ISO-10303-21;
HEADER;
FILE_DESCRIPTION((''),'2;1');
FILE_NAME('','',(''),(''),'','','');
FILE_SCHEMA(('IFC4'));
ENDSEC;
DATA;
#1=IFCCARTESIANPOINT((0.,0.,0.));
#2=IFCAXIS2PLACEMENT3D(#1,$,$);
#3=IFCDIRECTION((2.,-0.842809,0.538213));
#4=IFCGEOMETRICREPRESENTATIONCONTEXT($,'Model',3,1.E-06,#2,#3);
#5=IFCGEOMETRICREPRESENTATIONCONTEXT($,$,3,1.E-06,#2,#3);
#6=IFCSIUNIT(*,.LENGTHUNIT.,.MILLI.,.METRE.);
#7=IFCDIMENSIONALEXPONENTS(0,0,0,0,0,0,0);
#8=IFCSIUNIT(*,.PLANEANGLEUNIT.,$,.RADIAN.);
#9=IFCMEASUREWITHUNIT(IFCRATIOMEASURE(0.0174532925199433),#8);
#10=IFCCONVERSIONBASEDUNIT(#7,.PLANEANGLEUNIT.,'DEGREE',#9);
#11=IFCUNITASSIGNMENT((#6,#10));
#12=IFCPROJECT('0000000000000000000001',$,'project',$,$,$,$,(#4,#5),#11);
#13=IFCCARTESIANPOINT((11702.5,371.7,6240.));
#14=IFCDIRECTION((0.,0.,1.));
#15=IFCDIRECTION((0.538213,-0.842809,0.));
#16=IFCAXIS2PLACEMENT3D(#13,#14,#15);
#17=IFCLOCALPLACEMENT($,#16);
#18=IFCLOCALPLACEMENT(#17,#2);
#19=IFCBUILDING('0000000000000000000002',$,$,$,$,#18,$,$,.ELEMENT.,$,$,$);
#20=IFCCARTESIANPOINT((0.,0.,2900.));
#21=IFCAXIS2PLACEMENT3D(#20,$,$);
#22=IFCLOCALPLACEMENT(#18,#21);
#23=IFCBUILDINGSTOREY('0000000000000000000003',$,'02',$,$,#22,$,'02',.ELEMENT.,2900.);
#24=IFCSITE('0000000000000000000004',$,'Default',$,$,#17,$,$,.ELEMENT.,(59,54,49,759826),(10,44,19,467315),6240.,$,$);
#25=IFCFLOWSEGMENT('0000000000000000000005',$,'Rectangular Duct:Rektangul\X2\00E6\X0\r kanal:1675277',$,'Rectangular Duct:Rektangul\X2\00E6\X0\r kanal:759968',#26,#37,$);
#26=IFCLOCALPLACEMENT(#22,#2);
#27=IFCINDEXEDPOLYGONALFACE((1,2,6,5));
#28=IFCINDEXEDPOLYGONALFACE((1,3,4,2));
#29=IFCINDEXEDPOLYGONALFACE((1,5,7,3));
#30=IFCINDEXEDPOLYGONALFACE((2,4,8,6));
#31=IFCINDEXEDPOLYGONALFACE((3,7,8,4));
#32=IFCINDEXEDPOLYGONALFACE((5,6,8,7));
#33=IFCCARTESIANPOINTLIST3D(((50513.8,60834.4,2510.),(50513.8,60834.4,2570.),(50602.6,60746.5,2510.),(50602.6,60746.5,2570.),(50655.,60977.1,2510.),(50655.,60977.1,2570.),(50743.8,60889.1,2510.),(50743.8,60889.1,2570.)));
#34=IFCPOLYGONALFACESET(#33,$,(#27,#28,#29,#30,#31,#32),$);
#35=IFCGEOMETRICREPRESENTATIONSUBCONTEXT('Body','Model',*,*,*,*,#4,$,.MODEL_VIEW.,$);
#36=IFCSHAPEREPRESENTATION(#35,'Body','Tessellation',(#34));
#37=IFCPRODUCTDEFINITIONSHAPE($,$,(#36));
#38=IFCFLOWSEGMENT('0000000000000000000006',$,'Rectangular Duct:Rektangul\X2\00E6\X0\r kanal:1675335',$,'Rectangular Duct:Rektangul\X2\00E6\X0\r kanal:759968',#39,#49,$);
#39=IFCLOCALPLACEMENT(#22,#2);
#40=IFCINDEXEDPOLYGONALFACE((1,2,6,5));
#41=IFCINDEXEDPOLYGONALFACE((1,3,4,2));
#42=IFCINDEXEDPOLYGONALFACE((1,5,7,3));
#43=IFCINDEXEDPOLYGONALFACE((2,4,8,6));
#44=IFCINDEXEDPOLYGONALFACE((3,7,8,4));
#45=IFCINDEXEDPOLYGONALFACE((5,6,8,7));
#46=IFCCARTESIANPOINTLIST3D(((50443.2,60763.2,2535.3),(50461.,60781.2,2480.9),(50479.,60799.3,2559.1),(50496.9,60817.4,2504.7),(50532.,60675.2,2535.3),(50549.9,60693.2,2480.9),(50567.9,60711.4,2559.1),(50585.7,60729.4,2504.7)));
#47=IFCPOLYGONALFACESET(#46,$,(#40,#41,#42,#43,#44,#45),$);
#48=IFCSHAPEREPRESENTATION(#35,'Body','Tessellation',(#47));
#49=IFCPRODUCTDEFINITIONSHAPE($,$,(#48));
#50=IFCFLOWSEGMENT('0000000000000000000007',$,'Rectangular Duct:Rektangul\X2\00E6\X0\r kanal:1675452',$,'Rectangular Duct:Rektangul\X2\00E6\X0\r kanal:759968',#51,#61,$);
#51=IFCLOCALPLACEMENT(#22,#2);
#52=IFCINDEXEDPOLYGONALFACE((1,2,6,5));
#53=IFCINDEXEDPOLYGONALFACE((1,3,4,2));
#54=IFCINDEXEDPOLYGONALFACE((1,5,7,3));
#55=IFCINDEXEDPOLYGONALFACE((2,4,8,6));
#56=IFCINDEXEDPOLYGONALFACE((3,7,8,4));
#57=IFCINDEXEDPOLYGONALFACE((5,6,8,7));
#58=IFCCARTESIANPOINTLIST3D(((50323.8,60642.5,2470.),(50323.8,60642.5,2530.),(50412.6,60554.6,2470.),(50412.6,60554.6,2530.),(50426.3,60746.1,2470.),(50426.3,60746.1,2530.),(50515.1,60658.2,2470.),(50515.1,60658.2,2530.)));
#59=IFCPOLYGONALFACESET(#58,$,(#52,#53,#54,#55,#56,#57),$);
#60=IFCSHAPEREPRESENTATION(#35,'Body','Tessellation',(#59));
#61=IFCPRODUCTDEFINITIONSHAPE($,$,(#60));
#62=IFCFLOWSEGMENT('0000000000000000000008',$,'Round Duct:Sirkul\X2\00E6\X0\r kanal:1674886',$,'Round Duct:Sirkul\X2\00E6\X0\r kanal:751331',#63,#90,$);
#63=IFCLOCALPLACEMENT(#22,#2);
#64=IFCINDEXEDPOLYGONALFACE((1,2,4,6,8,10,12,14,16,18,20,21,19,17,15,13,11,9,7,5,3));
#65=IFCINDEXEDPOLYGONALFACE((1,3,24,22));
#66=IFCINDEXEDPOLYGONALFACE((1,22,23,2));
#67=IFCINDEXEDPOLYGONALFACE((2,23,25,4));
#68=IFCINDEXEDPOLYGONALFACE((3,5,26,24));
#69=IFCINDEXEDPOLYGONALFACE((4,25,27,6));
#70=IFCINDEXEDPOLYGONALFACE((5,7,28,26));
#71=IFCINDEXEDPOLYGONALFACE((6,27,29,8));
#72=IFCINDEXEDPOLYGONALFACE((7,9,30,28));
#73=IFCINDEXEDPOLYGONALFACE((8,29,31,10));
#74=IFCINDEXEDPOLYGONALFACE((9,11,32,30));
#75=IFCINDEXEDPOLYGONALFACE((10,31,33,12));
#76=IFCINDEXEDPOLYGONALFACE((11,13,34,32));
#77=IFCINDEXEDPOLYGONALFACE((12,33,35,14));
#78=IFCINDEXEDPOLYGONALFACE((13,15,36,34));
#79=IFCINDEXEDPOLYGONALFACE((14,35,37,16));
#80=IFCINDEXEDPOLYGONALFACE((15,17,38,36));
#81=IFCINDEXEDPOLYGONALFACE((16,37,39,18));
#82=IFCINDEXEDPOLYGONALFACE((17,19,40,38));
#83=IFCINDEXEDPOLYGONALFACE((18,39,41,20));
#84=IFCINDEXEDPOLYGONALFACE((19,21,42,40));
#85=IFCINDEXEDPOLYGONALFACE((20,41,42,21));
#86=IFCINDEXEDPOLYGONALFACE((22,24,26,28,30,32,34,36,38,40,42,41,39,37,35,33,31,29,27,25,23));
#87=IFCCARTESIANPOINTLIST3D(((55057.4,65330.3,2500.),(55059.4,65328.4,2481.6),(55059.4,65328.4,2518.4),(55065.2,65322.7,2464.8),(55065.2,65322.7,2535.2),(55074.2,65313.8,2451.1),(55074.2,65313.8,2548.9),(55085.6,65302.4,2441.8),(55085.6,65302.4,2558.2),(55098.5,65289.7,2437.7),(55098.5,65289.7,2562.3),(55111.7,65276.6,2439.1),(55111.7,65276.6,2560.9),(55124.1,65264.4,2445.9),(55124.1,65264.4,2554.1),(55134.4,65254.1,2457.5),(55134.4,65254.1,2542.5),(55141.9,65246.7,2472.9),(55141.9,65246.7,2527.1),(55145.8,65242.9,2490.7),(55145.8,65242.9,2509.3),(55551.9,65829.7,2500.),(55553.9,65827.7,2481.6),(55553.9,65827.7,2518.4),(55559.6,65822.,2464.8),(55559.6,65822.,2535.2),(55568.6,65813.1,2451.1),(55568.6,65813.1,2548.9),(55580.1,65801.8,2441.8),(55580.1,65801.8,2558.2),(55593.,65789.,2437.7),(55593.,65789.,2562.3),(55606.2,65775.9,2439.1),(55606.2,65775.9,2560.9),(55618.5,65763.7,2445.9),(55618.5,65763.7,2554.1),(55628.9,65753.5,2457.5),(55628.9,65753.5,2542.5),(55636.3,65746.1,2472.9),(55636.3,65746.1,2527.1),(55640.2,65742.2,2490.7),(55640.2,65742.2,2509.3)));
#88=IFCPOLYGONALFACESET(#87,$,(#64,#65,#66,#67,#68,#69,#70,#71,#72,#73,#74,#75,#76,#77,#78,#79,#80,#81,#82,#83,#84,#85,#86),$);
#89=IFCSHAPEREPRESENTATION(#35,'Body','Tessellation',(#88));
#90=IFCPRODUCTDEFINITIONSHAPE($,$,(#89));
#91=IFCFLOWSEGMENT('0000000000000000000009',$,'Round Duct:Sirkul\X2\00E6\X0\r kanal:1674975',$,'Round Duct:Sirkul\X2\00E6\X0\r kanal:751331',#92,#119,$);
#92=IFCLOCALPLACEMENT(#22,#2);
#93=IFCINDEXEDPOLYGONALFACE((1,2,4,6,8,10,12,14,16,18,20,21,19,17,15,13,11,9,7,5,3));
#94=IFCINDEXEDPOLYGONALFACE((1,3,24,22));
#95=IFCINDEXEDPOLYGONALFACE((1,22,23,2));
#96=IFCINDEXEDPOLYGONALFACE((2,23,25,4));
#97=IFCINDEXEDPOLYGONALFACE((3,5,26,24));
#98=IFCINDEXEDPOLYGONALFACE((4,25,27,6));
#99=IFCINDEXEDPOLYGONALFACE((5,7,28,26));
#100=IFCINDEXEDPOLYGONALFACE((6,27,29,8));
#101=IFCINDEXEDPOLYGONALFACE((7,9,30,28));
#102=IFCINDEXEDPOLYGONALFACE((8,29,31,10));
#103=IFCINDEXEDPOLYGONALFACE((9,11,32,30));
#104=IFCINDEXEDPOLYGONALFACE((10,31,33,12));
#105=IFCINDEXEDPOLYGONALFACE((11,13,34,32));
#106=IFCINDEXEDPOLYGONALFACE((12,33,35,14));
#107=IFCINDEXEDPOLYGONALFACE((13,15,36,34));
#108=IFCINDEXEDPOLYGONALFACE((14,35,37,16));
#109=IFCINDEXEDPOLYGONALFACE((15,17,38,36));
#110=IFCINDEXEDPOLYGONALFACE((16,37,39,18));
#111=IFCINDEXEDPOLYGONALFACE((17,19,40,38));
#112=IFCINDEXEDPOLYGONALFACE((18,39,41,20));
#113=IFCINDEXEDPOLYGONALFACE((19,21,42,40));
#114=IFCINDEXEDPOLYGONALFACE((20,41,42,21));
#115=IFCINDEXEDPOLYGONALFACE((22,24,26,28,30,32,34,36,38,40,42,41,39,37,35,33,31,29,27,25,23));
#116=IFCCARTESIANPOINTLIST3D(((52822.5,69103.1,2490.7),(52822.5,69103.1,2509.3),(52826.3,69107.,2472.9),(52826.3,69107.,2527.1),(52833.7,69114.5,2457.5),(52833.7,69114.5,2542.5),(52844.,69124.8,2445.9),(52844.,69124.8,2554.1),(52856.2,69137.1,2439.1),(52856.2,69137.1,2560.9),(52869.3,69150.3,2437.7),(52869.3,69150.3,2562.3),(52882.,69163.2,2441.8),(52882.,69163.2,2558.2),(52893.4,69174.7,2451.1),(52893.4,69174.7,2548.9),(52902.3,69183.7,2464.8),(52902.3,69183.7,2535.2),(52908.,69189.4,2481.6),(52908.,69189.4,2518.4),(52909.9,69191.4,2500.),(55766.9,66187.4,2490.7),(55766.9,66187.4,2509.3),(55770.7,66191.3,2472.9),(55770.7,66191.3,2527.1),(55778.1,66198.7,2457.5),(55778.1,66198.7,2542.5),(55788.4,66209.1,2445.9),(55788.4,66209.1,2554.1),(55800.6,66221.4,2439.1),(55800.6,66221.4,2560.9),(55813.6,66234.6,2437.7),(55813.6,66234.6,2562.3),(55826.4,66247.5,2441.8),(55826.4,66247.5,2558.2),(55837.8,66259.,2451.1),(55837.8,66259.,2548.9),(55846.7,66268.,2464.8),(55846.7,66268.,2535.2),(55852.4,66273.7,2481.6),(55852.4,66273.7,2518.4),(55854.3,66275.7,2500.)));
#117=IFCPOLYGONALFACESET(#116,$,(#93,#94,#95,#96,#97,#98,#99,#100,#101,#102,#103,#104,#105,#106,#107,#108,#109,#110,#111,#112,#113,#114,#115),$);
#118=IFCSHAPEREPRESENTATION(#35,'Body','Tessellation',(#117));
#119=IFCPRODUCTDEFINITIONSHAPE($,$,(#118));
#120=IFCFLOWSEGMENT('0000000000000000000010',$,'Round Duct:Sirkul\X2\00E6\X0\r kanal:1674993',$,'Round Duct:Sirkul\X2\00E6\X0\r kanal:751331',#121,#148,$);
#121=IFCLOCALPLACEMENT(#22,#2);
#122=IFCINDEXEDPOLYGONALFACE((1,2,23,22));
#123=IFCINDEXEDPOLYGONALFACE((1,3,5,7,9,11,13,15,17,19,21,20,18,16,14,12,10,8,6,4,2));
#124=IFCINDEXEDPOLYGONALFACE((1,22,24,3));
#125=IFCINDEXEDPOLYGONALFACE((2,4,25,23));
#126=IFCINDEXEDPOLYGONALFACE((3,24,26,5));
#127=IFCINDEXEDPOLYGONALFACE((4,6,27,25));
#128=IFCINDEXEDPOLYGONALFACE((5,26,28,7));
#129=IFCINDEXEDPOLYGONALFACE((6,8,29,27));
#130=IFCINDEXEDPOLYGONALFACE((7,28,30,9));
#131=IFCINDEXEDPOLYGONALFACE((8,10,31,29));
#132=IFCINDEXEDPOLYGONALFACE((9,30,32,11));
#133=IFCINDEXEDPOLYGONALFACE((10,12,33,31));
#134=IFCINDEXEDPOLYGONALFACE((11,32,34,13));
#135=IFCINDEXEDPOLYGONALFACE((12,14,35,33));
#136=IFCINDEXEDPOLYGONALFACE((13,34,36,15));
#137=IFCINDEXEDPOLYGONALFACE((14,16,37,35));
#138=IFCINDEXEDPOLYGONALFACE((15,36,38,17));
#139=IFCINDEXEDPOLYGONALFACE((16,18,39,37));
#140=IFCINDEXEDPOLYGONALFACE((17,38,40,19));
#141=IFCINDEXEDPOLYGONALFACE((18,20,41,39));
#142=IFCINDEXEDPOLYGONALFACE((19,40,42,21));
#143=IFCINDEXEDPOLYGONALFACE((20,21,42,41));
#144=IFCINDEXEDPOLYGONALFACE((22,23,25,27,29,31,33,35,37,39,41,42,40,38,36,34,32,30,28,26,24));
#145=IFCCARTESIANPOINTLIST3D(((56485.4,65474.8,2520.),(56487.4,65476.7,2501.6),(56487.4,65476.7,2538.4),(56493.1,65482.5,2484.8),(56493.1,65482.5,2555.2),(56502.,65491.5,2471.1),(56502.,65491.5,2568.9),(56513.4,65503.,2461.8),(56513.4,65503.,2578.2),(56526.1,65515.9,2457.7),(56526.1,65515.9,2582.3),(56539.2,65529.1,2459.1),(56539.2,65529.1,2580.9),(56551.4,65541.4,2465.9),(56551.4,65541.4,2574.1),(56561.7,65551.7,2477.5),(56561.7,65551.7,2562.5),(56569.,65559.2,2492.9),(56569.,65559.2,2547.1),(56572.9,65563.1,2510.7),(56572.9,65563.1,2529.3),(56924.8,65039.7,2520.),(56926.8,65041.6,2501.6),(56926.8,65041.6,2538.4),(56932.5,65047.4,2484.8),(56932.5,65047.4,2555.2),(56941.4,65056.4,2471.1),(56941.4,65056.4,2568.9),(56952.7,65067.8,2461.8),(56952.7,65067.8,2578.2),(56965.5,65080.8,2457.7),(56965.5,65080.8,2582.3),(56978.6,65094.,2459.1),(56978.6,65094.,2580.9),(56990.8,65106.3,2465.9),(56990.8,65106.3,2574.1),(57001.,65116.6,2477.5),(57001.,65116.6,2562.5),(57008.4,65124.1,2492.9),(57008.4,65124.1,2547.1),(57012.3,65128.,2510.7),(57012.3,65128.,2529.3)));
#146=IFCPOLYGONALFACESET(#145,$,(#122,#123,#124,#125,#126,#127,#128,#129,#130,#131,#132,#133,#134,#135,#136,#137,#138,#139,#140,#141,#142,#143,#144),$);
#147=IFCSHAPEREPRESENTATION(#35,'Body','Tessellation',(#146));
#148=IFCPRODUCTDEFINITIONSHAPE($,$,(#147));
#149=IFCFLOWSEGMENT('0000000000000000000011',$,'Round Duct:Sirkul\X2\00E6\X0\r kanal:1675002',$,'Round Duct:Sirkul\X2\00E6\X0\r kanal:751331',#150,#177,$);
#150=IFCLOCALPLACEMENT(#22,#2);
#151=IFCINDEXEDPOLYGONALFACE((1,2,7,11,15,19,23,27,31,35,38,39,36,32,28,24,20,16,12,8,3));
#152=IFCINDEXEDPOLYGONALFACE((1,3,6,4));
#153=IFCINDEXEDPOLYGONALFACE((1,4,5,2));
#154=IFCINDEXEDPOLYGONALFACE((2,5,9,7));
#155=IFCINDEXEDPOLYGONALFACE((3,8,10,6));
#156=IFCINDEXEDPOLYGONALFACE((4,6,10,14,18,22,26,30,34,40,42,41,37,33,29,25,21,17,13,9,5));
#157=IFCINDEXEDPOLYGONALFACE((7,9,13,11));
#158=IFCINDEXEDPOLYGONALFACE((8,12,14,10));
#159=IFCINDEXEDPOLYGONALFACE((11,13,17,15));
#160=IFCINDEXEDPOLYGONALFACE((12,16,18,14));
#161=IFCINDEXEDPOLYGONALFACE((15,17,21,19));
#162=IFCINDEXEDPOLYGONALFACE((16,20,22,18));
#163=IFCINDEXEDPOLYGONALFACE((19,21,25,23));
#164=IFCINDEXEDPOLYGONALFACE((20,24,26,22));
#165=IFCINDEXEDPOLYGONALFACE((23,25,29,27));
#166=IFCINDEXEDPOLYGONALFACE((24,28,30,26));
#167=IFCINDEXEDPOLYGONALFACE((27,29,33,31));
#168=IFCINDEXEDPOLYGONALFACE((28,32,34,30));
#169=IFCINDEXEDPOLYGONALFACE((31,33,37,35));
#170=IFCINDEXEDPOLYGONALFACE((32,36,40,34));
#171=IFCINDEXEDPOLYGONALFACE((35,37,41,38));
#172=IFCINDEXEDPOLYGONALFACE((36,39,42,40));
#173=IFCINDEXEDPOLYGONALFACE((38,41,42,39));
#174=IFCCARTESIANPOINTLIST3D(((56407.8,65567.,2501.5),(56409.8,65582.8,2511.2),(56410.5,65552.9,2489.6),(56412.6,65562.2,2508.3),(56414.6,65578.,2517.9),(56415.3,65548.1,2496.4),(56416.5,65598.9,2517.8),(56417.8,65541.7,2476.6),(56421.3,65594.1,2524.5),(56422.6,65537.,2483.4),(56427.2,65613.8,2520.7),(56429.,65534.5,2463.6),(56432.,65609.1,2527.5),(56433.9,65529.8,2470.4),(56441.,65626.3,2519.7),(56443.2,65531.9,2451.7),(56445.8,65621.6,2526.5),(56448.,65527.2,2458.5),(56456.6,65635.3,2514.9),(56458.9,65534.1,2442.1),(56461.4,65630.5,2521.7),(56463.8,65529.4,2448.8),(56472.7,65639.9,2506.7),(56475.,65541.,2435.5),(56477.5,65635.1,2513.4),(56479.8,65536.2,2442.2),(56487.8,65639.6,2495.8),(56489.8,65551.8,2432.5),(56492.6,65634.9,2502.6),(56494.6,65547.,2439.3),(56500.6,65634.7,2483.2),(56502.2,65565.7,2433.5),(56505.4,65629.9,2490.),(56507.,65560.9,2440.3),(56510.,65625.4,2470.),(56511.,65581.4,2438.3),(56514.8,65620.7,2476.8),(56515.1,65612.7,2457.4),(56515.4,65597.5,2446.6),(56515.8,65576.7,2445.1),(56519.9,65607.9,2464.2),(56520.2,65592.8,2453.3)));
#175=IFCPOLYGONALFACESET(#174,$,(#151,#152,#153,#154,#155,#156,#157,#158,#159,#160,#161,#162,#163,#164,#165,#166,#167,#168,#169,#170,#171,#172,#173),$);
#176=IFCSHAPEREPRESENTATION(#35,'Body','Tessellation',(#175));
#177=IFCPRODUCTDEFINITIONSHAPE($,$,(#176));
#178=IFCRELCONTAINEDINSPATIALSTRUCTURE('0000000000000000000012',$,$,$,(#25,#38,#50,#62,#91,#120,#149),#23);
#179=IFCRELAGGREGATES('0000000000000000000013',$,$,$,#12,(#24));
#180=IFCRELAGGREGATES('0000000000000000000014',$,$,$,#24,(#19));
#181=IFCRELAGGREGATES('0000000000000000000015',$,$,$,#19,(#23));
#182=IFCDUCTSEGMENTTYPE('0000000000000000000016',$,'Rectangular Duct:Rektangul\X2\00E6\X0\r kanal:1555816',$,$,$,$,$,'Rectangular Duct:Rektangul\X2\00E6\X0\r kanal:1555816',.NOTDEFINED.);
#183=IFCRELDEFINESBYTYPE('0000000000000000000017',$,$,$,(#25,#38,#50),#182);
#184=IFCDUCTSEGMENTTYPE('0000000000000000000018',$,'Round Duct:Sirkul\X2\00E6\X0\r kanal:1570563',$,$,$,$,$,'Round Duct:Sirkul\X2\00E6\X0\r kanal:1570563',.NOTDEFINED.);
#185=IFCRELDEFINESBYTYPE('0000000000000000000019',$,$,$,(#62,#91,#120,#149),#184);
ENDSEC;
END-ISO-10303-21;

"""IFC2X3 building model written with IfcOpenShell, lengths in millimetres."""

from ifc_helpers import new_model, entity, si_unit, converted_unit, direction, frame, frame_2d, origin, origin_2d_with_axis, place, context, subcontext, project, spatial, rectangle, circle, extrude, type_object, element, save


model = new_model("IFC2X3")

# Units and contexts
model_context = context("Model", 3, precision=1e-06, world=origin(), true_north=direction((2.0, -0.842809, 0.538213)))
context_of_model = context(None, 3, precision=1e-06, world=origin(), true_north=direction((2.0, -0.842809, 0.538213)))
body_context = subcontext(model_context, "Body", "Model", "MODEL_VIEW")
ifc_project = project(units=[si_unit("LENGTHUNIT", "METRE", prefix="MILLI"), converted_unit("PLANEANGLEUNIT", "DEGREE", entity("IfcRatioMeasure", 0.0174532925199433), si_unit("PLANEANGLEUNIT", "RADIAN"), dimensions=[0, 0, 0, 0, 0, 0, 0])], contexts=[model_context, context_of_model])

# Site, building, storey
site_placement = place(None, frame((11702.5, 371.7, 6240.0), z_axis=(0.0, 0.0, 1.0), x_axis=(0.538213, -0.842809, 0.0)))
site = spatial("IfcSite", under=ifc_project, at=site_placement, Name="Default", CompositionType="ELEMENT", RefLatitude=(59, 54, 49, 759826), RefLongitude=(10, 44, 19, 467315), RefElevation=6240.0)
building_placement = place(site_placement, origin())
building = spatial("IfcBuilding", under=site, at=building_placement, CompositionType="ELEMENT")
storey_placement = place(building_placement, frame((0.0, 0.0, 2900.0)))
storey = spatial("IfcBuildingStorey", under=building, at=storey_placement, Name="02", LongName="02", CompositionType="ELEMENT", Elevation=2900.0)

# Flow segments
duct_segment_type_1 = type_object("IfcDuctSegmentType", Name="Rectangular Duct:Rektangulær kanal:1555816", ElementType="Rectangular Duct:Rektangulær kanal:1555816", PredefinedType="NOTDEFINED")
flow_segment_1_placement = place(storey_placement, origin())
element("IfcFlowSegment", 1, at=flow_segment_1_placement, inside=storey, type_object=duct_segment_type_1, Name="Rectangular Duct:Rektangulær kanal:1675277", ObjectType="Rectangular Duct:Rektangulær kanal:759968", context=body_context, shape_type="SweptSolid", body=[
    extrude(rectangle(XDim=200.8, YDim=125.0, at=frame_2d((0.0, 0.0), x_axis=(1.0, 0.0))), frame((50628.8, 60861.8, 2510.0), z_axis=(0.0, 0.0, 1.0), x_axis=(-0.703643, -0.710554, 0.0)), (0.0, 0.0, 1.0), 60.0),
])
flow_segment_2_placement = place(storey_placement, origin())
element("IfcFlowSegment", 2, at=flow_segment_2_placement, inside=storey, type_object=duct_segment_type_1, Name="Rectangular Duct:Rektangulær kanal:1675335", ObjectType="Rectangular Duct:Rektangulær kanal:759968", context=body_context, shape_type="SweptSolid", body=[
    extrude(rectangle(XDim=60.0, YDim=56.2, at=frame_2d((0.0, 0.0), x_axis=(0.0, 1.0))), frame((50470.0, 60790.3, 2520.0), z_axis=(0.710554, -0.703643, 0.0), x_axis=(-0.637717, -0.643981, -0.422618)), (0.0, 0.0, 1.0), 125.0),
])
flow_segment_3_placement = place(storey_placement, origin())
element("IfcFlowSegment", 3, at=flow_segment_3_placement, inside=storey, type_object=duct_segment_type_1, Name="Rectangular Duct:Rektangulær kanal:1675452", ObjectType="Rectangular Duct:Rektangulær kanal:759968", context=body_context, shape_type="SweptSolid", body=[
    extrude(rectangle(XDim=145.8, YDim=125.0, at=origin_2d_with_axis()), frame((50419.5, 60650.4, 2470.0), z_axis=(0.0, 0.0, 1.0), x_axis=(-0.703643, -0.710554, 0.0)), (0.0, 0.0, 1.0), 60.0),
])
duct_segment_type_2 = type_object("IfcDuctSegmentType", Name="Round Duct:Sirkulær kanal:1570563", ElementType="Round Duct:Sirkulær kanal:1570563", PredefinedType="NOTDEFINED")
flow_segment_4_placement = place(storey_placement, origin())
element("IfcFlowSegment", 4, at=flow_segment_4_placement, inside=storey, type_object=duct_segment_type_2, Name="Round Duct:Sirkulær kanal:1674886", ObjectType="Round Duct:Sirkulær kanal:751331", context=body_context, shape_type="SweptSolid", body=[
    extrude(circle(Radius=62.5, at=origin_2d_with_axis()), frame((55101.8, 65286.4, 2500.0), z_axis=(0.703643, 0.710554, 0.0), x_axis=(-0.710554, 0.703643, 0.0)), (0.0, 0.0, 1.0), 702.8),
])
flow_segment_5_placement = place(storey_placement, origin())
element("IfcFlowSegment", 5, at=flow_segment_5_placement, inside=storey, type_object=duct_segment_type_2, Name="Round Duct:Sirkulær kanal:1674975", ObjectType="Round Duct:Sirkulær kanal:751331", context=body_context, shape_type="SweptSolid", body=[
    extrude(circle(Radius=62.5, at=frame_2d((0.0, 0.0), x_axis=(1.0, 0.0))), frame((52866.0, 69147.0, 2500.0), z_axis=(0.710554, -0.703643, 0.0), x_axis=(0.703643, 0.710554, 0.0)), (0.0, 0.0, 1.0), 4143.8),
])
flow_segment_6_placement = place(storey_placement, origin())
element("IfcFlowSegment", 6, at=flow_segment_6_placement, inside=storey, type_object=duct_segment_type_2, Name="Round Duct:Sirkulær kanal:1674993", ObjectType="Round Duct:Sirkulær kanal:751331", context=body_context, shape_type="SweptSolid", body=[
    extrude(circle(Radius=62.5, at=origin_2d_with_axis()), frame((56968.8, 65084.1, 2520.0), z_axis=(-0.710554, 0.703643, 0.0), x_axis=(-0.703643, -0.710554, 0.0)), (0.0, 0.0, 1.0), 618.4),
])
flow_segment_7_placement = place(storey_placement, origin())
element("IfcFlowSegment", 7, at=flow_segment_7_placement, inside=storey, type_object=duct_segment_type_2, Name="Round Duct:Sirkulær kanal:1675002", ObjectType="Round Duct:Sirkulær kanal:751331", context=body_context, shape_type="SweptSolid", body=[
    extrude(circle(Radius=62.5, at=frame_2d((0.0, 0.0), x_axis=(1.0, 0.0))), frame((56461.8, 65586.1, 2476.6), z_axis=(0.502437, -0.49755, 0.707107), x_axis=(-0.703643, -0.710554, 0.0)), (0.0, 0.0, 1.0), 9.6),
])

save(model, "model.ifc")
